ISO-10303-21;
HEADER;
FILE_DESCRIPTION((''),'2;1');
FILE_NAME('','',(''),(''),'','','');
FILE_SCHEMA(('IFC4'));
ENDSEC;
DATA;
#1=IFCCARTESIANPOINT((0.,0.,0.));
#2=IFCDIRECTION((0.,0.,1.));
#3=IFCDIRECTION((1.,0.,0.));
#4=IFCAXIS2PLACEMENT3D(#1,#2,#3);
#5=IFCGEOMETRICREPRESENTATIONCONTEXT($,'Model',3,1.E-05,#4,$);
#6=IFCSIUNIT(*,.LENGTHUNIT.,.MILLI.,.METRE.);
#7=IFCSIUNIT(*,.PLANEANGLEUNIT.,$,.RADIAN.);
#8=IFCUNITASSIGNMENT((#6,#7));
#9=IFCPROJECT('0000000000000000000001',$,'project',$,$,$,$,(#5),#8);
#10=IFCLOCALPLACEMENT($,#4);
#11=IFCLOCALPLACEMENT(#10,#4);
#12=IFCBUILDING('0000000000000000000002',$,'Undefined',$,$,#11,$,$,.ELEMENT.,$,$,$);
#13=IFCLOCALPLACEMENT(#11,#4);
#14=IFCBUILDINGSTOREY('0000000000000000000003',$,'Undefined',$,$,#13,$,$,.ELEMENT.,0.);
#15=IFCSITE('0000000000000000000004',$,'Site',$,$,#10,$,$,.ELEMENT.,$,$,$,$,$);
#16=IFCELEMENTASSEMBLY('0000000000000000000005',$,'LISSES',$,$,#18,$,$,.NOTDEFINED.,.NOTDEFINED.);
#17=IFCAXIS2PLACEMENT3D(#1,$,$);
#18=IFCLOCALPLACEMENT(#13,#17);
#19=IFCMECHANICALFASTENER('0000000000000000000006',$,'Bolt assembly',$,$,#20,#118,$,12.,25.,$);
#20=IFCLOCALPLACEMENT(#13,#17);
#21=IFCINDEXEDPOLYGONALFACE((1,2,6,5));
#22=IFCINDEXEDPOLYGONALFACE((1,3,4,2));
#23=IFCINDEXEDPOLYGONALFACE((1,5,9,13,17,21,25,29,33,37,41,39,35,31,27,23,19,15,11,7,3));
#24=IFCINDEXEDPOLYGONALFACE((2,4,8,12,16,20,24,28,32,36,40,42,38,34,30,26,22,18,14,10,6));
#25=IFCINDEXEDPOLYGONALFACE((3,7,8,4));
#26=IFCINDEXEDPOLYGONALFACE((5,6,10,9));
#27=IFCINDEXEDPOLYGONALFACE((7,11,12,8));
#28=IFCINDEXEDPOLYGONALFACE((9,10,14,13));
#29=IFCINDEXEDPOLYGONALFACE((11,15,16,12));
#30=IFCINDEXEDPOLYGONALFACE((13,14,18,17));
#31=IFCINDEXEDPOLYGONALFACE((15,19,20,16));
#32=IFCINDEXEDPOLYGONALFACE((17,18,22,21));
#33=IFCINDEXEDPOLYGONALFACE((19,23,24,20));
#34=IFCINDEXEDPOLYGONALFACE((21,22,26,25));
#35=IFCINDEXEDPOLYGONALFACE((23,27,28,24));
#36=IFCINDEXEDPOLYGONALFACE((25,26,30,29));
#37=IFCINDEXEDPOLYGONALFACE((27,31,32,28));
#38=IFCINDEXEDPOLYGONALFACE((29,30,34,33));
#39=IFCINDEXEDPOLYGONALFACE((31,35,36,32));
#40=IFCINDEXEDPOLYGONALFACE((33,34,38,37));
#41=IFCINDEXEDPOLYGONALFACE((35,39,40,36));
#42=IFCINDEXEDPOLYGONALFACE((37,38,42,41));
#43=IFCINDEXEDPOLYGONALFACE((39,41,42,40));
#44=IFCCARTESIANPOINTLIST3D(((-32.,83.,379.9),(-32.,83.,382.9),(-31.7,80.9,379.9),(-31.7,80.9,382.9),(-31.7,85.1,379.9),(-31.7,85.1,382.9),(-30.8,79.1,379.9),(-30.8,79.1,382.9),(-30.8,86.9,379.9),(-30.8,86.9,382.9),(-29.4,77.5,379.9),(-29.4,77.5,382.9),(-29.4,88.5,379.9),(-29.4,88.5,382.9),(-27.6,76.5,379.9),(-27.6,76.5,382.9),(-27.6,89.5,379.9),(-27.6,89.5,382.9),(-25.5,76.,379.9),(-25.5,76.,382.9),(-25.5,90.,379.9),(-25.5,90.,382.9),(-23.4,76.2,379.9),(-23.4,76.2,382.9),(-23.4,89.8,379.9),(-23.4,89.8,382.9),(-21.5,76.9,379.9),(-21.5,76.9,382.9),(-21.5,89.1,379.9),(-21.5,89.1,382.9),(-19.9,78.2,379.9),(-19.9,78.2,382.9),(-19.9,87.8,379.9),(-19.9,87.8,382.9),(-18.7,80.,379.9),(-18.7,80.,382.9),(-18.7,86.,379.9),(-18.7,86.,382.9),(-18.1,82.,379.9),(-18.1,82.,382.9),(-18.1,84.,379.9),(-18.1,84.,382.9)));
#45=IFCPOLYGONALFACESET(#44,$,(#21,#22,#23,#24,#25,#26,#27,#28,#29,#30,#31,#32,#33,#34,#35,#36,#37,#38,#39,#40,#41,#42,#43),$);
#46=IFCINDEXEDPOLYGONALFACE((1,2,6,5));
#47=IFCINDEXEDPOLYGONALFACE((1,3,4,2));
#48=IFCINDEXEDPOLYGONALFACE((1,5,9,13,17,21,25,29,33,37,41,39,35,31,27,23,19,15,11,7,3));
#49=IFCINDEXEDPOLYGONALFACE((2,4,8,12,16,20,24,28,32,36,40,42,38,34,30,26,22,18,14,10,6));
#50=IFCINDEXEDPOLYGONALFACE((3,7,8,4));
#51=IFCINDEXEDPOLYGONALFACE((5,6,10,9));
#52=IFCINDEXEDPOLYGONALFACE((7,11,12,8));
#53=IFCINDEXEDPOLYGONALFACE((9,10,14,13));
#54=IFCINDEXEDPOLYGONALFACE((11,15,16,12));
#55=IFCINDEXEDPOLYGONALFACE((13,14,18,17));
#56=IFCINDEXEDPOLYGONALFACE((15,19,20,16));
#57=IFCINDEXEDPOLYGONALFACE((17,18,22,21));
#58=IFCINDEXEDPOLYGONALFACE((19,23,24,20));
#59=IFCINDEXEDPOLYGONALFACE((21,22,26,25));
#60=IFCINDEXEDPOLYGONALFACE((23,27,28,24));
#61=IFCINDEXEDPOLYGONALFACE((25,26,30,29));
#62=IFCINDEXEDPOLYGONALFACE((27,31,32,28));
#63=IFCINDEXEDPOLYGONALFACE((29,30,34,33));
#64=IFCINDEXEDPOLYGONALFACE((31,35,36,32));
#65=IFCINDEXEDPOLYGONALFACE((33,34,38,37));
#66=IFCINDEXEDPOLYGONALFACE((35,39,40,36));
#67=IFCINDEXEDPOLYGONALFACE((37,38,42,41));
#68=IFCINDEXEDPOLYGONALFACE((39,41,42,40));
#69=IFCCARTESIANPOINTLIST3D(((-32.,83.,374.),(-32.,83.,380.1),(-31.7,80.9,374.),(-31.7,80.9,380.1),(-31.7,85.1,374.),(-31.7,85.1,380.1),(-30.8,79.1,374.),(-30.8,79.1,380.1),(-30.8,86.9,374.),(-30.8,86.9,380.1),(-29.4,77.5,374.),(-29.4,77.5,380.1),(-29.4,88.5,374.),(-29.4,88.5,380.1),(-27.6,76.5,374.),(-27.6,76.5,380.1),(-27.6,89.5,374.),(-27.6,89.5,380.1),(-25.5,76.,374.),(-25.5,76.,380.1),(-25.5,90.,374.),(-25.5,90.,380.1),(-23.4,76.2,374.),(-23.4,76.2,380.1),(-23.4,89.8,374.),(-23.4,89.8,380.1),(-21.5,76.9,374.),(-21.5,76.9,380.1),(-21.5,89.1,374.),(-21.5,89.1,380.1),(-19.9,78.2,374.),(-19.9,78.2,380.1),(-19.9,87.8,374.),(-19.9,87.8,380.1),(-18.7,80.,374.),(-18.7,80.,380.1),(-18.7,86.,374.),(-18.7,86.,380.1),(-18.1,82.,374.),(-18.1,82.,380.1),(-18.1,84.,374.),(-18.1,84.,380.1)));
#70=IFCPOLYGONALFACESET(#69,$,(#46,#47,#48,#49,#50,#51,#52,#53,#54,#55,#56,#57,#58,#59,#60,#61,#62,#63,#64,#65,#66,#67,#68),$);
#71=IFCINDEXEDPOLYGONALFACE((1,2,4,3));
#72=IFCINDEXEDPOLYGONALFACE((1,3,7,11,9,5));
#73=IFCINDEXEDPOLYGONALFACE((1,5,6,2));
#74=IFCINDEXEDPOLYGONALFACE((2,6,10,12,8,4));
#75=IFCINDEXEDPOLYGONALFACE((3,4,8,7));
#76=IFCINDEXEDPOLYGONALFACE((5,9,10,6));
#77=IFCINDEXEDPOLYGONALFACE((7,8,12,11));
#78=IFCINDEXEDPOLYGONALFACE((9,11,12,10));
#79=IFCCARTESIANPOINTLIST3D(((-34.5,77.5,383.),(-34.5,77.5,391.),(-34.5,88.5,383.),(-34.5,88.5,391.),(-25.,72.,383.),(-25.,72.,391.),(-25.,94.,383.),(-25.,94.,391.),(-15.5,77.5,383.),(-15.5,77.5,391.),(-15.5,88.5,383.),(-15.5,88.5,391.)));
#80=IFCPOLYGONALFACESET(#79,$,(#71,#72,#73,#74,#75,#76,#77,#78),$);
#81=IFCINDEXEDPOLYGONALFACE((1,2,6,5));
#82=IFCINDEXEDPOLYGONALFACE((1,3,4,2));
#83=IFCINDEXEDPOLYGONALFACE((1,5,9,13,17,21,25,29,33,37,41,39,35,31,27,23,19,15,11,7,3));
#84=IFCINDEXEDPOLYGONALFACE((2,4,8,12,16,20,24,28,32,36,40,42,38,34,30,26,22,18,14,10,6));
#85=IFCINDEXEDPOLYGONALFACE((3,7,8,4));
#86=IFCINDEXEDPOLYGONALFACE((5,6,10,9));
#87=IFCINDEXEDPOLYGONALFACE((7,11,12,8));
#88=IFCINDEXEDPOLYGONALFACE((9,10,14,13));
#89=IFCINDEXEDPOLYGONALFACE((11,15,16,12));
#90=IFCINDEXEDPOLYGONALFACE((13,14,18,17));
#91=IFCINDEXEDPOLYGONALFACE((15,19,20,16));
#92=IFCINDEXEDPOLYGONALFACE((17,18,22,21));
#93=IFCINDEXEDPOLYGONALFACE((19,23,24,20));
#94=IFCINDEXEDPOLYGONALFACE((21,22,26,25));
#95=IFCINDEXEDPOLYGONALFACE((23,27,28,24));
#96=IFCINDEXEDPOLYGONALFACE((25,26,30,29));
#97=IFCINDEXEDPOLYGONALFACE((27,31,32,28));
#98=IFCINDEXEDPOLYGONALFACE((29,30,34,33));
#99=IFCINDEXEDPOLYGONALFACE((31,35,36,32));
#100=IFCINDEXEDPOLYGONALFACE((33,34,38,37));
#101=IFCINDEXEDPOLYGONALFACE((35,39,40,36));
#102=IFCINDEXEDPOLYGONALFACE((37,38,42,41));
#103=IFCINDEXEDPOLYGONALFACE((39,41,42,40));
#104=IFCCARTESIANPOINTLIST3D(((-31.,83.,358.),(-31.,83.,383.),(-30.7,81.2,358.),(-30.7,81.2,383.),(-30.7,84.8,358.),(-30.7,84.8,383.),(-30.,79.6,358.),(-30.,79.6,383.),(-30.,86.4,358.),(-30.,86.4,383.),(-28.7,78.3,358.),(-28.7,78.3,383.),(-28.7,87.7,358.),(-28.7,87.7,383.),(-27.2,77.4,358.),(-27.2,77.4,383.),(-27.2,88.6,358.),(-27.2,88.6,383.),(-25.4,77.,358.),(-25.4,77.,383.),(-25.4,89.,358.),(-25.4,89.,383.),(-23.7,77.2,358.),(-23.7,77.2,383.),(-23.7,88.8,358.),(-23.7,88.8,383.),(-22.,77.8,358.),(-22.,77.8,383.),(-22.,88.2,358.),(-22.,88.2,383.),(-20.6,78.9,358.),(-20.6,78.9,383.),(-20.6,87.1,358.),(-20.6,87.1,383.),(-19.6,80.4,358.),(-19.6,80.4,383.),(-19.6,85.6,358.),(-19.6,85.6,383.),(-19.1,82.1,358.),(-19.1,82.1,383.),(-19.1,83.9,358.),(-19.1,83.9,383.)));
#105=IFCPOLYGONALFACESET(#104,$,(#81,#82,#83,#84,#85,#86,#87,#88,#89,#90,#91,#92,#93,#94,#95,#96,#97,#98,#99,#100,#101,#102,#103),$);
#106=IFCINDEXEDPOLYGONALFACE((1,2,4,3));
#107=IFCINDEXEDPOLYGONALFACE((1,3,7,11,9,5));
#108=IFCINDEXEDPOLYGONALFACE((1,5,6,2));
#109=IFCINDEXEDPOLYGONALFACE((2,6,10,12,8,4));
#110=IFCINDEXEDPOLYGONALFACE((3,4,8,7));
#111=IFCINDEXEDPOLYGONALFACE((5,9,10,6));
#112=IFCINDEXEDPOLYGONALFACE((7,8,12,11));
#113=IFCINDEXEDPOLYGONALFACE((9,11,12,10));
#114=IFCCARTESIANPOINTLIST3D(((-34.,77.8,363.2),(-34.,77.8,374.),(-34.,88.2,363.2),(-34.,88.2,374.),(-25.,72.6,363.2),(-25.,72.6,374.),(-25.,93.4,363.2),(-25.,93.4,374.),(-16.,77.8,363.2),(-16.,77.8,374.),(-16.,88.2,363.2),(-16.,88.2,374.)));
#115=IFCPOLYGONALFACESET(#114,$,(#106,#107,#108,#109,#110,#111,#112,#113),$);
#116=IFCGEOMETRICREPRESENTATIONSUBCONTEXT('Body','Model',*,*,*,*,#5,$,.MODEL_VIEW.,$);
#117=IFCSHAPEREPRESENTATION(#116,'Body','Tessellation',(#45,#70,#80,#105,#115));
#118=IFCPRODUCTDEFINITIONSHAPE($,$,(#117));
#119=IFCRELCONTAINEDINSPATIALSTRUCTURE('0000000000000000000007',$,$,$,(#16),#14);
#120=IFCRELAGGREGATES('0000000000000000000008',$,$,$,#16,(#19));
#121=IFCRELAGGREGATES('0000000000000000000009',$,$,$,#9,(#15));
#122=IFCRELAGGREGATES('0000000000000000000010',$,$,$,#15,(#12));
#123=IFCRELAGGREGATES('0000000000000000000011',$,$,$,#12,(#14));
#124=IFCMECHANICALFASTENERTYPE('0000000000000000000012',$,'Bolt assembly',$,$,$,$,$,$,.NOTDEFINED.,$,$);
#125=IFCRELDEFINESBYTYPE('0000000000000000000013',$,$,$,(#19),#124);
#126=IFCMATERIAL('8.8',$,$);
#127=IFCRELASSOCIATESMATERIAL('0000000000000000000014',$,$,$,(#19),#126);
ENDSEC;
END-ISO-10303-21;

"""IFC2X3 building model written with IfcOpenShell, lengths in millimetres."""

from ifc_helpers import new_model, si_unit, frame, origin_with_axes, origin_2d_with_axis, place, context, subcontext, project, spatial, polyline, circle, outline, extrude, source, transform, mapped, material, type_object, element, aggregate, save


model = new_model("IFC2X3")

# Units and contexts
model_context = context("Model", 3, precision=1e-05, world=origin_with_axes())
body_context = subcontext(model_context, "Body", "Model", "MODEL_VIEW")
ifc_project = project(units=[si_unit("LENGTHUNIT", "METRE", prefix="MILLI"), si_unit("PLANEANGLEUNIT", "RADIAN")], contexts=[model_context])

# Site, building, storey
site_placement = place(None, origin_with_axes())
site = spatial("IfcSite", under=ifc_project, at=site_placement, Name="Site", CompositionType="ELEMENT")
building_placement = place(site_placement, origin_with_axes())
building = spatial("IfcBuilding", under=site, at=building_placement, Name="Undefined", CompositionType="ELEMENT")
storey_placement = place(building_placement, origin_with_axes())
storey = spatial("IfcBuildingStorey", under=building, at=storey_placement, Name="Undefined", CompositionType="ELEMENT", Elevation=0.0)

# Shared definitions
ifc_material_1 = material(Name="8.8")
mechanical_fastener_type = type_object("IfcMechanicalFastenerType", Name="Bolt assembly")

# Element assembly, mechanical fastener
assembly_1_placement = place(storey_placement, origin_with_axes())
assembly_1 = element("IfcElementAssembly", 1, at=assembly_1_placement, inside=storey, Name="LISSES", AssemblyPlace="NOTDEFINED", PredefinedType="NOTDEFINED")
shared_shape_1 = source(origin_with_axes(), body_context, "Body", "SweptSolid", [
    extrude(circle(Radius=7.0, at=origin_2d_with_axis()), frame((0.0, -2.9, 0.0), z_axis=(0.0, 1.0, 0.0), x_axis=(1.0, 0.0, 0.0)), (0.0, 0.0, 1.0), 3.0),
    extrude(circle(Radius=7.0, at=origin_2d_with_axis()), frame((0.0, -0.1, 0.0), z_axis=(0.0, 1.0, 0.0), x_axis=(1.0, 0.0, 0.0)), (0.0, 0.0, 1.0), 6.1),
    extrude(outline(polyline([(9.5, -5.5), (9.5, 5.5), (0.0, 11.0), (-9.5, 5.5), (-9.5, -5.5), (0.0, -11.0), (9.5, -5.5)])), frame((0.0, -11.0, 0.0), z_axis=(0.0, 1.0, 0.0), x_axis=(1.0, 0.0, 0.0)), (0.0, 0.0, 1.0), 8.0),
    extrude(circle(Radius=6.0, at=origin_2d_with_axis()), frame((0.0, -3.0, 0.0), z_axis=(0.0, 1.0, 0.0), x_axis=(1.0, 0.0, 0.0)), (0.0, 0.0, 1.0), 25.0),
    extrude(outline(polyline([(9.0, -5.2), (9.0, 5.2), (0.0, 10.4), (-9.0, 5.2), (-9.0, -5.2), (0.0, -10.4), (9.0, -5.2)])), frame((0.0, 6.0, 0.0), z_axis=(0.0, 1.0, 0.0), x_axis=(1.0, 0.0, 0.0)), (0.0, 0.0, 1.0), 10.8),
])
mechanical_fastener_1_placement = place(assembly_1_placement, frame((-25.0, 83.0, 380.0), z_axis=(0.0, -1.0, 0.0), x_axis=(-1.0, 0.0, 0.0)))
mechanical_fastener_1 = element("IfcMechanicalFastener", 2, at=mechanical_fastener_1_placement, type_object=mechanical_fastener_type, material=ifc_material_1, Name="Bolt assembly", NominalDiameter=12.0, NominalLength=25.0, context=body_context, shape_type="MappedRepresentation", body=[
    mapped(shared_shape_1, transform((0.0, 0.0, 0.0))),
])
aggregate(assembly_1, [mechanical_fastener_1])

save(model, "model.ifc")
